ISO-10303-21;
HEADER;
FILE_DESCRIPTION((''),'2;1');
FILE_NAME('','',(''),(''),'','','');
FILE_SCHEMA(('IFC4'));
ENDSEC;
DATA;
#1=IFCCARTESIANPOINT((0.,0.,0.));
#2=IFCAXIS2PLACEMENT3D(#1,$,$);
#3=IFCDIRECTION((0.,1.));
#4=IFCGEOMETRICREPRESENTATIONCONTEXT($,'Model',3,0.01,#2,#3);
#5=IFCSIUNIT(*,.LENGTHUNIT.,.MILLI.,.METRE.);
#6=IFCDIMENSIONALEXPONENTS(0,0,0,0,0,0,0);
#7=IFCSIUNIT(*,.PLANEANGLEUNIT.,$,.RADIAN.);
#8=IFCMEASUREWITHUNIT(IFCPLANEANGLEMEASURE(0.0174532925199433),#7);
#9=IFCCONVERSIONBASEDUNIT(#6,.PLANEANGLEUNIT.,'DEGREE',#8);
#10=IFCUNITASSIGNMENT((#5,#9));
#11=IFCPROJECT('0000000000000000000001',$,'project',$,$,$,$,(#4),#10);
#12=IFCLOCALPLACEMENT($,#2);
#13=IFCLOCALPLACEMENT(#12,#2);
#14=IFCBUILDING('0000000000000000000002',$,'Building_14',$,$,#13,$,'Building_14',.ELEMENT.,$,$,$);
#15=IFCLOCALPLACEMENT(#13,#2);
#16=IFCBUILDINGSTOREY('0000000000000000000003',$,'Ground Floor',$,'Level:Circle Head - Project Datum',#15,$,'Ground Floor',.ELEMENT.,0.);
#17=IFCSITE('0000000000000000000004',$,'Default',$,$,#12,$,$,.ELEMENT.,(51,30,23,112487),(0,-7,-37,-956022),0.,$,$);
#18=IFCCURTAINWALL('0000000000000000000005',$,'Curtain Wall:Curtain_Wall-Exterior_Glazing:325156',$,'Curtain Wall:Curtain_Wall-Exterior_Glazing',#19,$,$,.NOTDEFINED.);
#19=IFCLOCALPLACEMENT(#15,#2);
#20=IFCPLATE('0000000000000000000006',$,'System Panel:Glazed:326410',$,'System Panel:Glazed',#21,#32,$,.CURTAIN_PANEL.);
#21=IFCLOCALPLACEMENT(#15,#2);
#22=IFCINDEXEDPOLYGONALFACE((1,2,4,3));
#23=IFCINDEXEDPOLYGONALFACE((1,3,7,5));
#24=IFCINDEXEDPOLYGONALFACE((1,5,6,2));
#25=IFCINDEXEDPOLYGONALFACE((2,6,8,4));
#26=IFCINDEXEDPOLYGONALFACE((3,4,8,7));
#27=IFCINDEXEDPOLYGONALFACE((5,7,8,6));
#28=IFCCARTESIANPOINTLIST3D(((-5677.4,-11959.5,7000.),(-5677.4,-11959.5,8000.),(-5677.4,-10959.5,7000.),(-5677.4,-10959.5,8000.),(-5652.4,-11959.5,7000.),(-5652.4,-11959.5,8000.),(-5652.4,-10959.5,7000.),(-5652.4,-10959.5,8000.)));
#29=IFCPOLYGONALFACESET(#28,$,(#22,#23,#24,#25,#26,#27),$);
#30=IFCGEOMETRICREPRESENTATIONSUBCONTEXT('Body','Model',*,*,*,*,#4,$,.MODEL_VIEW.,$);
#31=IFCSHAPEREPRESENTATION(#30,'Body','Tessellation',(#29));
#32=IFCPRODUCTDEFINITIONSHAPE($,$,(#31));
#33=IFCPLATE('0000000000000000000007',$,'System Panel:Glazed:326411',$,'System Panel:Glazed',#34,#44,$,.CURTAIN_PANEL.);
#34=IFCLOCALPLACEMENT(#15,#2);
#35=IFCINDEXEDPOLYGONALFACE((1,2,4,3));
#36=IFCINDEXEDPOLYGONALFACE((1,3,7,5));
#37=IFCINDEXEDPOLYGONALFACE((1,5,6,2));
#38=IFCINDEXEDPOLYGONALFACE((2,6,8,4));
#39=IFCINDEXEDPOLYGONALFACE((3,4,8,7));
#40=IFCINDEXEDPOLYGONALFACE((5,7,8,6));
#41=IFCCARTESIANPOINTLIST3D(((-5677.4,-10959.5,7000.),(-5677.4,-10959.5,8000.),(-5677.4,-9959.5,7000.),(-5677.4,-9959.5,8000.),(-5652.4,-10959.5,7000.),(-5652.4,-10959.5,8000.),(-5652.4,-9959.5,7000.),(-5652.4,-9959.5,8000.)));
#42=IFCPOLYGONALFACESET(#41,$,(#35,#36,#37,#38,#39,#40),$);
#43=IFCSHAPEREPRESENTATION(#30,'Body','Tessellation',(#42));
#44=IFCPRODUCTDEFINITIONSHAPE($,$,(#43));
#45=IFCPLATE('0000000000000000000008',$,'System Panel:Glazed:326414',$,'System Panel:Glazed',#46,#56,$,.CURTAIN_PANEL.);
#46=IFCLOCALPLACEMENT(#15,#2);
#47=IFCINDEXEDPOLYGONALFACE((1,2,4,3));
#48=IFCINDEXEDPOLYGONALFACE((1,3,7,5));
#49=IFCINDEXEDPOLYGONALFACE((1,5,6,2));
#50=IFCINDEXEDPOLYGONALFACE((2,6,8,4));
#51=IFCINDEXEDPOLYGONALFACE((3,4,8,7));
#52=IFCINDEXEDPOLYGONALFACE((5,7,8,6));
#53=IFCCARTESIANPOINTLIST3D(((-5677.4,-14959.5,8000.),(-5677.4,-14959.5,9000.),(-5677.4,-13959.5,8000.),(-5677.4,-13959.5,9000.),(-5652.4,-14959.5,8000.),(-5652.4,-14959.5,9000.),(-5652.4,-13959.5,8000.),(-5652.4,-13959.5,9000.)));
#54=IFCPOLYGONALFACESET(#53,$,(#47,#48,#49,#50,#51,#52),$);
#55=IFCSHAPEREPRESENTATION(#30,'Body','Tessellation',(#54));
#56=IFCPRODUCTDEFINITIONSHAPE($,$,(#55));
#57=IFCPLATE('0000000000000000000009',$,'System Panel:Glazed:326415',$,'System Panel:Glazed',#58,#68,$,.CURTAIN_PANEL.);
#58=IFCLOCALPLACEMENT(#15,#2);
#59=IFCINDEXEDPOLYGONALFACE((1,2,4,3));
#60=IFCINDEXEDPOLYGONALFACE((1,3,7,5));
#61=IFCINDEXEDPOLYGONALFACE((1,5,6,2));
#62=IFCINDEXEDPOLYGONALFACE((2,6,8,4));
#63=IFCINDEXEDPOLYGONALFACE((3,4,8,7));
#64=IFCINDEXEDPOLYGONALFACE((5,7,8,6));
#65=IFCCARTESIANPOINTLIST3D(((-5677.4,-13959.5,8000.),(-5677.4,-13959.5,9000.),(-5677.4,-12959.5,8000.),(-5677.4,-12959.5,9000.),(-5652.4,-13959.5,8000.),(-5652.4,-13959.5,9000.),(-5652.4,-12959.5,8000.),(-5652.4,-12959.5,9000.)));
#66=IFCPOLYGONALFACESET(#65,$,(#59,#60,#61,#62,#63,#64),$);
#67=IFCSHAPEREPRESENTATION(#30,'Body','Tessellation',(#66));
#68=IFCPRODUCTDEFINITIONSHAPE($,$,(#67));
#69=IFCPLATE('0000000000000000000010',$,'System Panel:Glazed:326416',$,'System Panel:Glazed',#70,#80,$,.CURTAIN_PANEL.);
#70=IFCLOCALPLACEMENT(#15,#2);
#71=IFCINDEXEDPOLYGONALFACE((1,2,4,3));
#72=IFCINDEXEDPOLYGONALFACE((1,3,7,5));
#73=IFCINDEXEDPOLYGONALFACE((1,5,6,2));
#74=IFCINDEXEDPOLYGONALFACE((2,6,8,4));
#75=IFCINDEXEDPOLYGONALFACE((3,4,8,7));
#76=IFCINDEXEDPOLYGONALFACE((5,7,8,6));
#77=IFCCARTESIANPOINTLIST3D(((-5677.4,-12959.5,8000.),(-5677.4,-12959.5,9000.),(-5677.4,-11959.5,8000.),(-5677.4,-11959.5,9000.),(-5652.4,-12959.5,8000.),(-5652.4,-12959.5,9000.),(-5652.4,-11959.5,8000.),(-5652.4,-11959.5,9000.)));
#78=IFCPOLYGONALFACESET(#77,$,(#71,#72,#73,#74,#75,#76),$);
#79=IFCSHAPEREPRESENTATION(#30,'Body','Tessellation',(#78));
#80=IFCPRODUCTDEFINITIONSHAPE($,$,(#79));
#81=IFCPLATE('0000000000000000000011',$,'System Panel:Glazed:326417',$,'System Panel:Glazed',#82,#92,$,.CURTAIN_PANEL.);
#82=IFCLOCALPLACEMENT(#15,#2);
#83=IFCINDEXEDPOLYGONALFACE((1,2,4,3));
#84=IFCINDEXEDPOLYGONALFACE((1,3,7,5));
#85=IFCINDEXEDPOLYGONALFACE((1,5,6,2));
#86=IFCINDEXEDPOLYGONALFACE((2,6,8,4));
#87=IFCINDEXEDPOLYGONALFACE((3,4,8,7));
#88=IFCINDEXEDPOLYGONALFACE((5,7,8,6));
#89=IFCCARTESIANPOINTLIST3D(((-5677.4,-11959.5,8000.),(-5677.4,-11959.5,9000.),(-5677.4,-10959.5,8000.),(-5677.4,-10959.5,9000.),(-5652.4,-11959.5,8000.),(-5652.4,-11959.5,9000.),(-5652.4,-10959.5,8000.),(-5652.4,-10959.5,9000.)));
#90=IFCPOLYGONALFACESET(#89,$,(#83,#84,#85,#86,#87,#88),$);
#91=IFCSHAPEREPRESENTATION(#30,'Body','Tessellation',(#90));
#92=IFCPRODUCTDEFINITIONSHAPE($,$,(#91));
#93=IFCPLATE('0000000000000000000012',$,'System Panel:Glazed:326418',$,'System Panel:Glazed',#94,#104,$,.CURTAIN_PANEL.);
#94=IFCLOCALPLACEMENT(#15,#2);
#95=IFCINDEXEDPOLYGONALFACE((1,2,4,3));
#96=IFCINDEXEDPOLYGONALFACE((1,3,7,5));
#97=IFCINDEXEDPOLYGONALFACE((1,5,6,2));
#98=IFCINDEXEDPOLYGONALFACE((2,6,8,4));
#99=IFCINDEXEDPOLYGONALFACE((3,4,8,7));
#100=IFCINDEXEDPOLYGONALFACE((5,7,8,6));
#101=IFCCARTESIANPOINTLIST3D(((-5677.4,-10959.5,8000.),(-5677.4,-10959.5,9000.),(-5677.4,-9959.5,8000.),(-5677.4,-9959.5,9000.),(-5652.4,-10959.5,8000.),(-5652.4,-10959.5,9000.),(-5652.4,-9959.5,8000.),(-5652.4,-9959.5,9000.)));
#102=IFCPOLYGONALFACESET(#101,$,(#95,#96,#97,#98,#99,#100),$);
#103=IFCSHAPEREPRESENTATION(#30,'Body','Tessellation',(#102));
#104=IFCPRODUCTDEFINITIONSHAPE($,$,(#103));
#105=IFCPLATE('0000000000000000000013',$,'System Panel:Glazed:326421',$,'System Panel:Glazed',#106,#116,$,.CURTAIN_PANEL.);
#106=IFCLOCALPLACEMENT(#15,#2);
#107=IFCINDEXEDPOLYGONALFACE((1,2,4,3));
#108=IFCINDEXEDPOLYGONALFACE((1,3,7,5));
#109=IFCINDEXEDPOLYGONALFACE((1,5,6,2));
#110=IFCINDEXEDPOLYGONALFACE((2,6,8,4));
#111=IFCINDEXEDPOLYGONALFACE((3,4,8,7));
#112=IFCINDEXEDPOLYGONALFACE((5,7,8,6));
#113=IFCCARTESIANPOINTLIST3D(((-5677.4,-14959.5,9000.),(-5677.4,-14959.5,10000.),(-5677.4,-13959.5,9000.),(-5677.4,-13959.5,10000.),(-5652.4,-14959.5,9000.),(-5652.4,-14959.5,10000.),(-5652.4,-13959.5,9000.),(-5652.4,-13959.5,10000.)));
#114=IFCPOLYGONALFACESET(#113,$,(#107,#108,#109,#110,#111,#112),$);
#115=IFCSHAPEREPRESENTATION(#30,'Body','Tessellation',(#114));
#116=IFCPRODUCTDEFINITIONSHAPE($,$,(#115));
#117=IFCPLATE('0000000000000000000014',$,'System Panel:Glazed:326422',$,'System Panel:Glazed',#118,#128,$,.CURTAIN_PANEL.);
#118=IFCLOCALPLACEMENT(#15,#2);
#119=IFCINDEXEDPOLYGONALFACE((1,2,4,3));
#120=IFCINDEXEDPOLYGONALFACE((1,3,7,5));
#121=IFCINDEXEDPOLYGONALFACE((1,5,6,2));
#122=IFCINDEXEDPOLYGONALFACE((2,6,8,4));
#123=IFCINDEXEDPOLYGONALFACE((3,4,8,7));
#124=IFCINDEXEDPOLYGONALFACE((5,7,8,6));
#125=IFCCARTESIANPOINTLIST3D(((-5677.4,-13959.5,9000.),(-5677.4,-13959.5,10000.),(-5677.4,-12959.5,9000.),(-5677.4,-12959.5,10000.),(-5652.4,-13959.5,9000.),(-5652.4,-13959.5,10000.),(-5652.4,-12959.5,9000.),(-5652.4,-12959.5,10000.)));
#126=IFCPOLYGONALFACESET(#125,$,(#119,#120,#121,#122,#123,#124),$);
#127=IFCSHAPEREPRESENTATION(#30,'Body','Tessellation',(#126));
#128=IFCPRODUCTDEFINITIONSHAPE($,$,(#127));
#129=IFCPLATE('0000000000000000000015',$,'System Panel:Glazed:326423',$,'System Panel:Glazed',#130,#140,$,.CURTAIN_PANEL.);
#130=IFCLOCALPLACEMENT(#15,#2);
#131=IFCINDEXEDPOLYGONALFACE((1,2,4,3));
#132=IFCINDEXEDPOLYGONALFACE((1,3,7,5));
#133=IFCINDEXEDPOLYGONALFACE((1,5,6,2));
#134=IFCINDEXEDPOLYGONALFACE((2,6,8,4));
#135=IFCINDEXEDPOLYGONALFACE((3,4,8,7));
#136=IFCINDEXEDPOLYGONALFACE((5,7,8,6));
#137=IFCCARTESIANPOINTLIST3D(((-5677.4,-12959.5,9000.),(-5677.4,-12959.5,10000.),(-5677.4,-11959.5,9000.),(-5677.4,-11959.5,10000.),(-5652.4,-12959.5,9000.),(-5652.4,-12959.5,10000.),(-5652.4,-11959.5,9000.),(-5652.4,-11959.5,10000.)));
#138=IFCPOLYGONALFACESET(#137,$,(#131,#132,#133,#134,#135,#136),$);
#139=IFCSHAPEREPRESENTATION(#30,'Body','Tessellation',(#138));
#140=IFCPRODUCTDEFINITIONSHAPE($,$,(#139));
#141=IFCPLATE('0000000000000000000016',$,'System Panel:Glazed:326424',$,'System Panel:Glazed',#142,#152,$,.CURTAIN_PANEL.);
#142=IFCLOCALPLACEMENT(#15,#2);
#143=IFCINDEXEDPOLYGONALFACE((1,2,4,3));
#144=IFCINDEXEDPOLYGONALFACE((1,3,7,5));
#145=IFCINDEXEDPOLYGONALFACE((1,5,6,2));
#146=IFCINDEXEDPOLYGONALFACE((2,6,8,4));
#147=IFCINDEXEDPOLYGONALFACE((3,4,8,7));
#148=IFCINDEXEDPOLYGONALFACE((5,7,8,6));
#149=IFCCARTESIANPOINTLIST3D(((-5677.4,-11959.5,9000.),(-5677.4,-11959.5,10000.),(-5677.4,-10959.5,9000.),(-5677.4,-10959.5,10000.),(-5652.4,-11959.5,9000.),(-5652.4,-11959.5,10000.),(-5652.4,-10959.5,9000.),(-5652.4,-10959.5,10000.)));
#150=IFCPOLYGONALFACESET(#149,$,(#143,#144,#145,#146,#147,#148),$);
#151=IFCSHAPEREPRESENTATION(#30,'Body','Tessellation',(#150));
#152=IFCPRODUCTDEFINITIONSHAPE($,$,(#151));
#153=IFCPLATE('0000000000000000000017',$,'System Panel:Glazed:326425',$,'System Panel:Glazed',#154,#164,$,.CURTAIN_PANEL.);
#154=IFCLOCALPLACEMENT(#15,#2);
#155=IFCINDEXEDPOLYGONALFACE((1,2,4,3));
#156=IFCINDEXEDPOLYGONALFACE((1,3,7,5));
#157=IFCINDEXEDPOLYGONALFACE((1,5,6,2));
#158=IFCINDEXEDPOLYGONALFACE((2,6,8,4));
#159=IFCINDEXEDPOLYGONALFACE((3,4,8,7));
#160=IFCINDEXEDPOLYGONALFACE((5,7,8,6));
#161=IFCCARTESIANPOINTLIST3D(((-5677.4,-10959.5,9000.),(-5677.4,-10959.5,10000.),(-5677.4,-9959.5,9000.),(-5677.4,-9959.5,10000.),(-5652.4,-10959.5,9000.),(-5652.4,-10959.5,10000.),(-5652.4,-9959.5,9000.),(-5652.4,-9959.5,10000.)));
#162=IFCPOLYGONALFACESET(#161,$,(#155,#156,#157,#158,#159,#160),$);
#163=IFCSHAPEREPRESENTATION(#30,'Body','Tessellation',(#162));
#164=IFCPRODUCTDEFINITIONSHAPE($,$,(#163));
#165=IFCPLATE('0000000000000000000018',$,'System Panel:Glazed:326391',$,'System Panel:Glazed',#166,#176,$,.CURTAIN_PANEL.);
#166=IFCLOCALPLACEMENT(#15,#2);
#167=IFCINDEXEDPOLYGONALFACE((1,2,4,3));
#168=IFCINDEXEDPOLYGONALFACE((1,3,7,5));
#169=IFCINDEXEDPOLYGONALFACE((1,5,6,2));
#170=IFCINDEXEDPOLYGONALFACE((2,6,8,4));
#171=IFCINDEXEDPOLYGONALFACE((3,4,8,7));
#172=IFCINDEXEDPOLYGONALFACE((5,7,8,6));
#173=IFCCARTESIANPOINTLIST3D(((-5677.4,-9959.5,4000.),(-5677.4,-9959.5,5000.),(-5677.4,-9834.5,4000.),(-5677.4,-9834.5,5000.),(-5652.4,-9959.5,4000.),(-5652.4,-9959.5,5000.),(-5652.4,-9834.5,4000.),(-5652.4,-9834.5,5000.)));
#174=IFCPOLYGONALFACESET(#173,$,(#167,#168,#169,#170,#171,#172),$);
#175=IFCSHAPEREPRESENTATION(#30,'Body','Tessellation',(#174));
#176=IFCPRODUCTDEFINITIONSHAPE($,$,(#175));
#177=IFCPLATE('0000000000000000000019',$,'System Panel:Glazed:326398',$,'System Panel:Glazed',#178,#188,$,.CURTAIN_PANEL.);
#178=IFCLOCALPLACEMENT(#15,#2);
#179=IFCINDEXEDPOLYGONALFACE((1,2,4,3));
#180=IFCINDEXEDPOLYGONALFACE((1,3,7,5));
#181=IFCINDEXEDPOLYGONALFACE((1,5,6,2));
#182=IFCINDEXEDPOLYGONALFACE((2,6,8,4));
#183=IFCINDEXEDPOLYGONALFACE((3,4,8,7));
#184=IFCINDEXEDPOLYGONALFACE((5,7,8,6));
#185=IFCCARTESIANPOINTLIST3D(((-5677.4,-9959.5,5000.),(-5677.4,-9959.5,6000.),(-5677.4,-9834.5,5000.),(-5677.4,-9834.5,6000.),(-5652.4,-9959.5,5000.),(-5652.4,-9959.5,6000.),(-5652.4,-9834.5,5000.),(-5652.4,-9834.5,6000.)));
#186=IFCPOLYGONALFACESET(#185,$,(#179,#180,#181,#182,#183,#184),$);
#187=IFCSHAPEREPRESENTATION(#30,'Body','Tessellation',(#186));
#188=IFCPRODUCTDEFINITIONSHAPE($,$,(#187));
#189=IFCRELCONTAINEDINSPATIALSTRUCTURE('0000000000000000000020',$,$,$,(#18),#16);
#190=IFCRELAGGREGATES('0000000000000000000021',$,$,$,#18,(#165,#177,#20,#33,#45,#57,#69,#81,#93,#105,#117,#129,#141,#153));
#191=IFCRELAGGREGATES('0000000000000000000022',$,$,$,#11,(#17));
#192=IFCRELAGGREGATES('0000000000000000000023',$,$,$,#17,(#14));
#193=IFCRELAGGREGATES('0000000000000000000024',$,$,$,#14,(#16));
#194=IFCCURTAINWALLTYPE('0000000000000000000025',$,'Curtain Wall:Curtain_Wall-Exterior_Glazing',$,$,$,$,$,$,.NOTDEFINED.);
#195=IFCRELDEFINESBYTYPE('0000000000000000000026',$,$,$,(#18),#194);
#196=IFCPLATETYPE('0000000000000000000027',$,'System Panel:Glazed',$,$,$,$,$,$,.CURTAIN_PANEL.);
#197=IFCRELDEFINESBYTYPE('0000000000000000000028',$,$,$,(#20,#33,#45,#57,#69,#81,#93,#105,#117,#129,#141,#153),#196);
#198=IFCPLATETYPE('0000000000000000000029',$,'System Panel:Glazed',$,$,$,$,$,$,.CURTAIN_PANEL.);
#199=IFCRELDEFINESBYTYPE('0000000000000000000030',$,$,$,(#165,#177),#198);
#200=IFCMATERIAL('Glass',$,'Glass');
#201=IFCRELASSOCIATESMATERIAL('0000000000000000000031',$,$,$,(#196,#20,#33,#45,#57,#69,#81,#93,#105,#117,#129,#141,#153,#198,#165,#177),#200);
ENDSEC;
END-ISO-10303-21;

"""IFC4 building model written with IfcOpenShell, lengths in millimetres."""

from ifc_helpers import new_model, entity, si_unit, converted_unit, direction, frame, origin, place, context, subcontext, project, spatial, indexed_curve, outline, extrude, source, transform, mapped, material, type_object, type_shapes, element, aggregate, save


model = new_model("IFC4")

# Units and contexts
model_context = context("Model", 3, precision=0.01, world=origin(), true_north=direction((0.0, 1.0)))
body_context = subcontext(model_context, "Body", "Model", "MODEL_VIEW")
ifc_project = project(units=[si_unit("LENGTHUNIT", "METRE", prefix="MILLI"), converted_unit("PLANEANGLEUNIT", "DEGREE", entity("IfcPlaneAngleMeasure", 0.0174532925199433), si_unit("PLANEANGLEUNIT", "RADIAN"), dimensions=[0, 0, 0, 0, 0, 0, 0])], contexts=[model_context])

# Site, building, storey
site_placement = place(None, origin())
site = spatial("IfcSite", under=ifc_project, at=site_placement, Name="Default", CompositionType="ELEMENT", RefLatitude=(51, 30, 23, 112487), RefLongitude=(0, -7, -37, -956022), RefElevation=0.0)
building_placement = place(site_placement, origin())
building = spatial("IfcBuilding", under=site, at=building_placement, Name="Building_14", LongName="Building_14", CompositionType="ELEMENT")
storey_placement = place(building_placement, origin())
storey = spatial("IfcBuildingStorey", under=building, at=storey_placement, Name="Ground Floor", ObjectType="Level:Circle Head - Project Datum", LongName="Ground Floor", CompositionType="ELEMENT", Elevation=0.0)

# Curtain wall, plates
curtain_wall_type = type_object("IfcCurtainWallType", Name="Curtain Wall:Curtain_Wall-Exterior_Glazing", PredefinedType="NOTDEFINED")
curtain_wall_1_placement = place(storey_placement, origin())
curtain_wall_1 = element("IfcCurtainWall", 1, at=curtain_wall_1_placement, inside=storey, type_object=curtain_wall_type, Name="Curtain Wall:Curtain_Wall-Exterior_Glazing:325156", ObjectType="Curtain Wall:Curtain_Wall-Exterior_Glazing", PredefinedType="NOTDEFINED")
ifc_material = material(Name="Glass", Category="Glass")
plate_type_1 = type_object("IfcPlateType", Name="System Panel:Glazed", PredefinedType="CURTAIN_PANEL", material=ifc_material)
shared_shape_1 = source(origin(), body_context, "Body", "SweptSolid", [
    extrude(outline(indexed_curve([(-12.5, -500.0), (12.5, -500.0), (12.5, 500.0), (-12.5, 500.0), (-12.5, -500.0)], self_intersect=False)), frame((0.0, -37.0, 0.0), z_axis=(0.0, 0.0, 1.0), x_axis=(0.0, 1.0, 0.0)), (0.0, 0.0, 1.0), 1000.0),
])
type_shapes(plate_type_1, [shared_shape_1])
plate_1_placement = place(curtain_wall_1_placement, frame((-5701.9, -11459.5, 7000.0), z_axis=(0.0, 0.0, 1.0), x_axis=(0.0, 1.0, 0.0)))
plate_1 = element("IfcPlate", 2, at=plate_1_placement, type_object=plate_type_1, material=ifc_material, Name="System Panel:Glazed:326410", ObjectType="System Panel:Glazed", PredefinedType="CURTAIN_PANEL", context=body_context, shape_type="MappedRepresentation", body=[
    mapped(shared_shape_1, transform((0.0, 0.0, 0.0), scale=1.0)),
])
plate_2_placement = place(curtain_wall_1_placement, frame((-5701.9, -10459.5, 7000.0), z_axis=(0.0, 0.0, 1.0), x_axis=(0.0, 1.0, 0.0)))
plate_2 = element("IfcPlate", 3, at=plate_2_placement, type_object=plate_type_1, material=ifc_material, Name="System Panel:Glazed:326411", ObjectType="System Panel:Glazed", PredefinedType="CURTAIN_PANEL", context=body_context, shape_type="MappedRepresentation", body=[
    mapped(shared_shape_1, transform((0.0, 0.0, 0.0), scale=1.0)),
])
plate_3_placement = place(curtain_wall_1_placement, frame((-5701.9, -14459.5, 8000.0), z_axis=(0.0, 0.0, 1.0), x_axis=(0.0, 1.0, 0.0)))
plate_3 = element("IfcPlate", 4, at=plate_3_placement, type_object=plate_type_1, material=ifc_material, Name="System Panel:Glazed:326414", ObjectType="System Panel:Glazed", PredefinedType="CURTAIN_PANEL", context=body_context, shape_type="MappedRepresentation", body=[
    mapped(shared_shape_1, transform((0.0, 0.0, 0.0), scale=1.0)),
])
plate_4_placement = place(curtain_wall_1_placement, frame((-5701.9, -13459.5, 8000.0), z_axis=(0.0, 0.0, 1.0), x_axis=(0.0, 1.0, 0.0)))
plate_4 = element("IfcPlate", 5, at=plate_4_placement, type_object=plate_type_1, material=ifc_material, Name="System Panel:Glazed:326415", ObjectType="System Panel:Glazed", PredefinedType="CURTAIN_PANEL", context=body_context, shape_type="MappedRepresentation", body=[
    mapped(shared_shape_1, transform((0.0, 0.0, 0.0), scale=1.0)),
])
plate_5_placement = place(curtain_wall_1_placement, frame((-5701.9, -12459.5, 8000.0), z_axis=(0.0, 0.0, 1.0), x_axis=(0.0, 1.0, 0.0)))
plate_5 = element("IfcPlate", 6, at=plate_5_placement, type_object=plate_type_1, material=ifc_material, Name="System Panel:Glazed:326416", ObjectType="System Panel:Glazed", PredefinedType="CURTAIN_PANEL", context=body_context, shape_type="MappedRepresentation", body=[
    mapped(shared_shape_1, transform((0.0, 0.0, 0.0), scale=1.0)),
])
plate_6_placement = place(curtain_wall_1_placement, frame((-5701.9, -11459.5, 8000.0), z_axis=(0.0, 0.0, 1.0), x_axis=(0.0, 1.0, 0.0)))
plate_6 = element("IfcPlate", 7, at=plate_6_placement, type_object=plate_type_1, material=ifc_material, Name="System Panel:Glazed:326417", ObjectType="System Panel:Glazed", PredefinedType="CURTAIN_PANEL", context=body_context, shape_type="MappedRepresentation", body=[
    mapped(shared_shape_1, transform((0.0, 0.0, 0.0), scale=1.0)),
])
plate_7_placement = place(curtain_wall_1_placement, frame((-5701.9, -10459.5, 8000.0), z_axis=(0.0, 0.0, 1.0), x_axis=(0.0, 1.0, 0.0)))
plate_7 = element("IfcPlate", 8, at=plate_7_placement, type_object=plate_type_1, material=ifc_material, Name="System Panel:Glazed:326418", ObjectType="System Panel:Glazed", PredefinedType="CURTAIN_PANEL", context=body_context, shape_type="MappedRepresentation", body=[
    mapped(shared_shape_1, transform((0.0, 0.0, 0.0), scale=1.0)),
])
plate_8_placement = place(curtain_wall_1_placement, frame((-5701.9, -14459.5, 9000.0), z_axis=(0.0, 0.0, 1.0), x_axis=(0.0, 1.0, 0.0)))
plate_8 = element("IfcPlate", 9, at=plate_8_placement, type_object=plate_type_1, material=ifc_material, Name="System Panel:Glazed:326421", ObjectType="System Panel:Glazed", PredefinedType="CURTAIN_PANEL", context=body_context, shape_type="MappedRepresentation", body=[
    mapped(shared_shape_1, transform((0.0, 0.0, 0.0), scale=1.0)),
])
plate_9_placement = place(curtain_wall_1_placement, frame((-5701.9, -13459.5, 9000.0), z_axis=(0.0, 0.0, 1.0), x_axis=(0.0, 1.0, 0.0)))
plate_9 = element("IfcPlate", 10, at=plate_9_placement, type_object=plate_type_1, material=ifc_material, Name="System Panel:Glazed:326422", ObjectType="System Panel:Glazed", PredefinedType="CURTAIN_PANEL", context=body_context, shape_type="MappedRepresentation", body=[
    mapped(shared_shape_1, transform((0.0, 0.0, 0.0), scale=1.0)),
])
plate_10_placement = place(curtain_wall_1_placement, frame((-5701.9, -12459.5, 9000.0), z_axis=(0.0, 0.0, 1.0), x_axis=(0.0, 1.0, 0.0)))
plate_10 = element("IfcPlate", 11, at=plate_10_placement, type_object=plate_type_1, material=ifc_material, Name="System Panel:Glazed:326423", ObjectType="System Panel:Glazed", PredefinedType="CURTAIN_PANEL", context=body_context, shape_type="MappedRepresentation", body=[
    mapped(shared_shape_1, transform((0.0, 0.0, 0.0), scale=1.0)),
])
plate_11_placement = place(curtain_wall_1_placement, frame((-5701.9, -11459.5, 9000.0), z_axis=(0.0, 0.0, 1.0), x_axis=(0.0, 1.0, 0.0)))
plate_11 = element("IfcPlate", 12, at=plate_11_placement, type_object=plate_type_1, material=ifc_material, Name="System Panel:Glazed:326424", ObjectType="System Panel:Glazed", PredefinedType="CURTAIN_PANEL", context=body_context, shape_type="MappedRepresentation", body=[
    mapped(shared_shape_1, transform((0.0, 0.0, 0.0), scale=1.0)),
])
plate_12_placement = place(curtain_wall_1_placement, frame((-5701.9, -10459.5, 9000.0), z_axis=(0.0, 0.0, 1.0), x_axis=(0.0, 1.0, 0.0)))
plate_12 = element("IfcPlate", 13, at=plate_12_placement, type_object=plate_type_1, material=ifc_material, Name="System Panel:Glazed:326425", ObjectType="System Panel:Glazed", PredefinedType="CURTAIN_PANEL", context=body_context, shape_type="MappedRepresentation", body=[
    mapped(shared_shape_1, transform((0.0, 0.0, 0.0), scale=1.0)),
])
plate_type_2 = type_object("IfcPlateType", Name="System Panel:Glazed", PredefinedType="CURTAIN_PANEL", material=ifc_material)
shared_shape_2 = source(origin(), body_context, "Body", "SweptSolid", [
    extrude(outline(indexed_curve([(-12.5, -62.5), (12.5, -62.5), (12.5, 62.5), (-12.5, 62.5), (-12.5, -62.5)], self_intersect=False)), frame((0.0, -37.0, 0.0), z_axis=(0.0, 0.0, 1.0), x_axis=(0.0, 1.0, 0.0)), (0.0, 0.0, 1.0), 1000.0),
])
type_shapes(plate_type_2, [shared_shape_2])
plate_13_placement = place(curtain_wall_1_placement, frame((-5701.9, -9897.0, 4000.0), z_axis=(0.0, 0.0, 1.0), x_axis=(0.0, 1.0, 0.0)))
plate_13 = element("IfcPlate", 14, at=plate_13_placement, type_object=plate_type_2, material=ifc_material, Name="System Panel:Glazed:326391", ObjectType="System Panel:Glazed", PredefinedType="CURTAIN_PANEL", context=body_context, shape_type="MappedRepresentation", body=[
    mapped(shared_shape_2, transform((0.0, 0.0, 0.0), scale=1.0)),
])
plate_14_placement = place(curtain_wall_1_placement, frame((-5701.9, -9897.0, 5000.0), z_axis=(0.0, 0.0, 1.0), x_axis=(0.0, 1.0, 0.0)))
plate_14 = element("IfcPlate", 15, at=plate_14_placement, type_object=plate_type_2, material=ifc_material, Name="System Panel:Glazed:326398", ObjectType="System Panel:Glazed", PredefinedType="CURTAIN_PANEL", context=body_context, shape_type="MappedRepresentation", body=[
    mapped(shared_shape_2, transform((0.0, 0.0, 0.0), scale=1.0)),
])
aggregate(curtain_wall_1, [plate_13, plate_14, plate_1, plate_2, plate_3, plate_4, plate_5, plate_6, plate_7, plate_8, plate_9, plate_10, plate_11, plate_12])

save(model, "model.ifc")
